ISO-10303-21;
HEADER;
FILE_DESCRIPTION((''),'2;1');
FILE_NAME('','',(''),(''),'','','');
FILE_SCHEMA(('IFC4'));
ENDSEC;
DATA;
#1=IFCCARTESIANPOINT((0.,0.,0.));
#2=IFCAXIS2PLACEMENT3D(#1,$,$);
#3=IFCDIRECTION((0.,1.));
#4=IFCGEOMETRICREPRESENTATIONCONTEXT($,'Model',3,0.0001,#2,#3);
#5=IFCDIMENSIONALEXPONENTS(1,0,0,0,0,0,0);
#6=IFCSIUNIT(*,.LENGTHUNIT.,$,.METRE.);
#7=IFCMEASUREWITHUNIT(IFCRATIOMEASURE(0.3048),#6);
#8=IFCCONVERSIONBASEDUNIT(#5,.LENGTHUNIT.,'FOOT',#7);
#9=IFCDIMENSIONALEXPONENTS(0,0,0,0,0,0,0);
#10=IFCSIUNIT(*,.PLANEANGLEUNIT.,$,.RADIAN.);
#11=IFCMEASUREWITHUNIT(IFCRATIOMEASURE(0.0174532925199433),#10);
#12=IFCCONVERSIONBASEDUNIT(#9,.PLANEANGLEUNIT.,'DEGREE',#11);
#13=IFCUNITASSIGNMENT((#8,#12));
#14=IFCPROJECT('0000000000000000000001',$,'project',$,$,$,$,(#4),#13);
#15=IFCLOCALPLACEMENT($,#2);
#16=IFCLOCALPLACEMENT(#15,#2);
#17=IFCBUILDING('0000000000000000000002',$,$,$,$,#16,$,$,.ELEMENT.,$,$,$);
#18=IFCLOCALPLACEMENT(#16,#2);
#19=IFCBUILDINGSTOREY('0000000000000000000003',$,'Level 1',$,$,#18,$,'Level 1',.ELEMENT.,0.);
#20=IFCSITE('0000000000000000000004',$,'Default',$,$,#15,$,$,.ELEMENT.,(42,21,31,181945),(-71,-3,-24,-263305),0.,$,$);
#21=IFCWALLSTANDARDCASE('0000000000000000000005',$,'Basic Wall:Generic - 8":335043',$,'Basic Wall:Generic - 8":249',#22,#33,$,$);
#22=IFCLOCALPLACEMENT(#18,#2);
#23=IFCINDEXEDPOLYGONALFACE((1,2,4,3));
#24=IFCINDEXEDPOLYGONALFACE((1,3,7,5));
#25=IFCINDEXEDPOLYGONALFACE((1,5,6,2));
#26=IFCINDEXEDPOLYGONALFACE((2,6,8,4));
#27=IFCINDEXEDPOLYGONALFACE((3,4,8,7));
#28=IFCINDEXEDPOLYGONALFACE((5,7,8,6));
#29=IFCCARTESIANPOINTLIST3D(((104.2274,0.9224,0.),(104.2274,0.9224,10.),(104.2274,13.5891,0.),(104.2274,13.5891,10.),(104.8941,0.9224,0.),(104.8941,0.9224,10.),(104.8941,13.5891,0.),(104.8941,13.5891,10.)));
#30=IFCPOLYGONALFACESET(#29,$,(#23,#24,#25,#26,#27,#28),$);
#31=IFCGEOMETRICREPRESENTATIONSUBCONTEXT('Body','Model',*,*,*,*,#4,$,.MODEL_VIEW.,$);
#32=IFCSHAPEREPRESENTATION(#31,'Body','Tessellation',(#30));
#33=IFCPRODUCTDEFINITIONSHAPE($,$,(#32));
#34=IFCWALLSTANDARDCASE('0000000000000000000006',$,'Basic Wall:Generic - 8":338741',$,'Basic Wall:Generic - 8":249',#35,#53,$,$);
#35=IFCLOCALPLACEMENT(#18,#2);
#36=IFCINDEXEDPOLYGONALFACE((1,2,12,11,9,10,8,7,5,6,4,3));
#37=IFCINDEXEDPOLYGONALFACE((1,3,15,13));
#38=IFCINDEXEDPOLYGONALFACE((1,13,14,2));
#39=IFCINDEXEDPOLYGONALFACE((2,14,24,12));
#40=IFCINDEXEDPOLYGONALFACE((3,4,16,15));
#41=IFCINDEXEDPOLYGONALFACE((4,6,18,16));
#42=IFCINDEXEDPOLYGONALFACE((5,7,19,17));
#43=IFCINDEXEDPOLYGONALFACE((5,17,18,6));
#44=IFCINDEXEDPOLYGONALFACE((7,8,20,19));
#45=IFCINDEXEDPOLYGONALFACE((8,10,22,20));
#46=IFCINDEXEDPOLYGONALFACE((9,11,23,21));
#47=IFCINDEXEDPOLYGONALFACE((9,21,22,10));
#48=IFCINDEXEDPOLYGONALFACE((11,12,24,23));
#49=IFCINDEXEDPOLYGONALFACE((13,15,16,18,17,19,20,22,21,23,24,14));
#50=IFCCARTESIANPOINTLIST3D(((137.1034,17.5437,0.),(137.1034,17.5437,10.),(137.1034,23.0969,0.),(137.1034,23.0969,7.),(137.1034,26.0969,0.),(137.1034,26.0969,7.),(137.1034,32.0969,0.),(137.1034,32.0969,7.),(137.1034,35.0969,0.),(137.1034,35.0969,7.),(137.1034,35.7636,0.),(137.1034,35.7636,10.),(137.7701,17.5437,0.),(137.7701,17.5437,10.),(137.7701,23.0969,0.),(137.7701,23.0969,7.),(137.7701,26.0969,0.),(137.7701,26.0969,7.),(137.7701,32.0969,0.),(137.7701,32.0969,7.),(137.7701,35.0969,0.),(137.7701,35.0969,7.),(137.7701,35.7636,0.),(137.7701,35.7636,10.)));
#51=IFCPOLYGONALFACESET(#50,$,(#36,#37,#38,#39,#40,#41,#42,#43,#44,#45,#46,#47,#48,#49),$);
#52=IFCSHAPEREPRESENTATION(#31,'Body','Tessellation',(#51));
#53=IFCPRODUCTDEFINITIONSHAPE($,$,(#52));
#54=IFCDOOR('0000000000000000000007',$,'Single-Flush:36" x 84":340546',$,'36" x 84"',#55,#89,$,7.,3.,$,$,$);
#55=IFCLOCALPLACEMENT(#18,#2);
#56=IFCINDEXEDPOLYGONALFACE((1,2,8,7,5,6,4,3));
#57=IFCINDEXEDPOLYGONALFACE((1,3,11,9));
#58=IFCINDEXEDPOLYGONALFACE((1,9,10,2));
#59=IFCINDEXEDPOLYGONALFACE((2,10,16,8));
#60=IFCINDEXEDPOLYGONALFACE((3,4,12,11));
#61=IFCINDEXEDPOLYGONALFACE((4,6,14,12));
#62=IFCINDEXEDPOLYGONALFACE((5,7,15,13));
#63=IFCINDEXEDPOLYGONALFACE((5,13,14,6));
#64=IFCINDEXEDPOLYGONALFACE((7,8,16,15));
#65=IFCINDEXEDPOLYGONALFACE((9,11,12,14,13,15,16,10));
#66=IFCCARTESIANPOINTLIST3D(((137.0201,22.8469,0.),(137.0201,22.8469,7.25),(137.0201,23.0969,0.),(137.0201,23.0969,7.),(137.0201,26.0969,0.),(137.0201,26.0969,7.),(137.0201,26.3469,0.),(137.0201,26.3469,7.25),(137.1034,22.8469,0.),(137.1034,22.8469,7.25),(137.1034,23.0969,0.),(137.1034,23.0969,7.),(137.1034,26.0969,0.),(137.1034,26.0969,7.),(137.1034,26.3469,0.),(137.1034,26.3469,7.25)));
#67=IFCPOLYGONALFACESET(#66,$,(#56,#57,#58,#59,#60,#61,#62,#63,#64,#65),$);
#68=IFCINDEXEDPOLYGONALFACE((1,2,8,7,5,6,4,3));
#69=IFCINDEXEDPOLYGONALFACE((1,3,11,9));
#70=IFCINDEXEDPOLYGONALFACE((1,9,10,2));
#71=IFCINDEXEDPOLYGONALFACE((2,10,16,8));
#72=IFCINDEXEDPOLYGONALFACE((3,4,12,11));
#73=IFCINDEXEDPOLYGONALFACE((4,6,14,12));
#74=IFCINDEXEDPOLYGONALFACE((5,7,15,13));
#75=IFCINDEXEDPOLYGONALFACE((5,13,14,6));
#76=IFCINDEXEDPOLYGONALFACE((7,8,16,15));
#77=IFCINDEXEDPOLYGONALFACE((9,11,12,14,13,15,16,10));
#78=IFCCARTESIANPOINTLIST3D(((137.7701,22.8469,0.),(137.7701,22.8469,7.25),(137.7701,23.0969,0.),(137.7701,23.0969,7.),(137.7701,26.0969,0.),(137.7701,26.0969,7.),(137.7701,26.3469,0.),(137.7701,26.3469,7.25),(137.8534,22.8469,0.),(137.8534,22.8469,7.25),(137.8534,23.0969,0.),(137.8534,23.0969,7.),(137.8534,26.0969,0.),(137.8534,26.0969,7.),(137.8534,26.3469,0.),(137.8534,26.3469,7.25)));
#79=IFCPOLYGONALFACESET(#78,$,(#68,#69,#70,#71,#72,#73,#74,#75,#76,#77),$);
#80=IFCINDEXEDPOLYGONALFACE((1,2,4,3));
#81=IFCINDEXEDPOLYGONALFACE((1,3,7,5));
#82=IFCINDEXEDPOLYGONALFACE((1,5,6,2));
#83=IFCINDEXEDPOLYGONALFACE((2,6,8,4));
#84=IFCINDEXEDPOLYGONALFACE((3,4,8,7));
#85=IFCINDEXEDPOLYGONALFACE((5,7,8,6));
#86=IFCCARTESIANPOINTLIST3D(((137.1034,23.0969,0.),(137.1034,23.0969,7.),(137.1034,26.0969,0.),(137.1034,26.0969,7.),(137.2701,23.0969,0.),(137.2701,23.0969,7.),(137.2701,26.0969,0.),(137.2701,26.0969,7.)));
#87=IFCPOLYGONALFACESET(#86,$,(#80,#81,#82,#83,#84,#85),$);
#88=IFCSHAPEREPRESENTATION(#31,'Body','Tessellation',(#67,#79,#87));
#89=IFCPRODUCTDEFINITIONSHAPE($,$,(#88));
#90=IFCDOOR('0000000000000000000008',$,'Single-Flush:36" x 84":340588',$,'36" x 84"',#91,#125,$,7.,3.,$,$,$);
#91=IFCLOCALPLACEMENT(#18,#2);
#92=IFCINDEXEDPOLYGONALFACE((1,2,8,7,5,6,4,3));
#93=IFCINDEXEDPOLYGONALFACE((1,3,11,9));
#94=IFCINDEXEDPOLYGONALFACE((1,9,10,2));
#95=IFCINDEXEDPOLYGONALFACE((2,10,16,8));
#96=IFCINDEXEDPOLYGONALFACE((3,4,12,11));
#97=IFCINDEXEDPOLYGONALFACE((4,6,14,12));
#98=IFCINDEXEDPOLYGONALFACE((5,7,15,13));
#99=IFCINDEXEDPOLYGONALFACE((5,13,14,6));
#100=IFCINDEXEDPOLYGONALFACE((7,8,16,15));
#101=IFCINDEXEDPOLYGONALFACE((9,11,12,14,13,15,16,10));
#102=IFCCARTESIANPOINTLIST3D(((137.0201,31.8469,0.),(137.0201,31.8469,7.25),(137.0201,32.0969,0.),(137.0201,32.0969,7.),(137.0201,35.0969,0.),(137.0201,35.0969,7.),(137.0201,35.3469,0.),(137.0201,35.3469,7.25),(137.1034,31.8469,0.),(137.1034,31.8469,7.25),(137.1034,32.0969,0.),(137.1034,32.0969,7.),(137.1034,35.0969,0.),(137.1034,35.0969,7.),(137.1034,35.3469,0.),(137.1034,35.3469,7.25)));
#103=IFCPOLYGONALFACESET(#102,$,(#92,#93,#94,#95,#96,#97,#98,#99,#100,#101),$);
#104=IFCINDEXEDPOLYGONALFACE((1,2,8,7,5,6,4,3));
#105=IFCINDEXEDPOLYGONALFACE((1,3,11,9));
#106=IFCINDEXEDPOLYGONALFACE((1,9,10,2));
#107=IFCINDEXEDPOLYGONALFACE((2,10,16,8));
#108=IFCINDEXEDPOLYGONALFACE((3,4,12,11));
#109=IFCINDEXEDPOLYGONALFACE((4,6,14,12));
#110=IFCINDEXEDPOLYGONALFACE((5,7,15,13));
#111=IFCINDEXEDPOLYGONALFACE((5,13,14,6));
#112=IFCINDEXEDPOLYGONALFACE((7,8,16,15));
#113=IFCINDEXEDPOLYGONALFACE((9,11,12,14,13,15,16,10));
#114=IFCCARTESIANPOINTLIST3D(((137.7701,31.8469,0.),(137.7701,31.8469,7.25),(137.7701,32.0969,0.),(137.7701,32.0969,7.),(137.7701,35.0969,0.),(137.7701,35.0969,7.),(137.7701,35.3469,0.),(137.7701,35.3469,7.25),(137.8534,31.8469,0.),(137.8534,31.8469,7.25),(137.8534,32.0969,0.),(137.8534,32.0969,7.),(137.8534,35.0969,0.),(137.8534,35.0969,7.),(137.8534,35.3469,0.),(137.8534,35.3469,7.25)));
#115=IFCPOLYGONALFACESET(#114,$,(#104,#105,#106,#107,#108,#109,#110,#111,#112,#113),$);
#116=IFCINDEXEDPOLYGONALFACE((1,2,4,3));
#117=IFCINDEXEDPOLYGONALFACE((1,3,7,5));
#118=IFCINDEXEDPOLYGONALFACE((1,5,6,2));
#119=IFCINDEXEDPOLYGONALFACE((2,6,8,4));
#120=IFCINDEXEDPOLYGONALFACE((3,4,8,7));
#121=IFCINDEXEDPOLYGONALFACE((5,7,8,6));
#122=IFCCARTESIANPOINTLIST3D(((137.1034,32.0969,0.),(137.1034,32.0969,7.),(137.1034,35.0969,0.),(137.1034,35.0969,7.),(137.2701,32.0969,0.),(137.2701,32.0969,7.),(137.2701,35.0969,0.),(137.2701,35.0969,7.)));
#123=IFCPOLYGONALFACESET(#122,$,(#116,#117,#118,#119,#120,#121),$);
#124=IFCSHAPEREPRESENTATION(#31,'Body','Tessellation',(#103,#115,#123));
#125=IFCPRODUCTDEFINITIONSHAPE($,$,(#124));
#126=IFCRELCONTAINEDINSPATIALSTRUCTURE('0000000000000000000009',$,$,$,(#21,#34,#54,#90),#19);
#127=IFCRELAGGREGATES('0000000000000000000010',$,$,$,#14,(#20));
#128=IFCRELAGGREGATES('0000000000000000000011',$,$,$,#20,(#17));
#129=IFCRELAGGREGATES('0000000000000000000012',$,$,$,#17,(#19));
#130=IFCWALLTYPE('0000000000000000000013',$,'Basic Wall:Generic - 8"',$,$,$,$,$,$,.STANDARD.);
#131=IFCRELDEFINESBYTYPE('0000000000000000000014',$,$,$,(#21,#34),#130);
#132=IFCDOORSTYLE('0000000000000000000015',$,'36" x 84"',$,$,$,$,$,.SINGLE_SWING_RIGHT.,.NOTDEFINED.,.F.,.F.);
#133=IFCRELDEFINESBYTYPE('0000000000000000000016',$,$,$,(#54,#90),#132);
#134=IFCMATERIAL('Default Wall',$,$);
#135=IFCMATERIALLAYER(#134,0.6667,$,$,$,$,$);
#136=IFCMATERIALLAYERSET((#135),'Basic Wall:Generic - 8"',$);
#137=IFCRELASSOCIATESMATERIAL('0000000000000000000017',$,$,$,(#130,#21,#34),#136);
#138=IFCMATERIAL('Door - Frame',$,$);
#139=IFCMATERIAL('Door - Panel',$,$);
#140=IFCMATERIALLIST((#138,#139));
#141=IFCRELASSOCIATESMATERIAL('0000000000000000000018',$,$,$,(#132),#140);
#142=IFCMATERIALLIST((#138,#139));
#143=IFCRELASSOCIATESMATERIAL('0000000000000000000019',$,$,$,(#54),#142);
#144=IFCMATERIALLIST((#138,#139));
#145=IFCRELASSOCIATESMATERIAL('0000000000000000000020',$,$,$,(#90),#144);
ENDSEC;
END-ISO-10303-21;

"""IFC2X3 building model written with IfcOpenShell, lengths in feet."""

from ifc_helpers import new_model, entity, si_unit, converted_unit, direction, frame, frame_2d, origin, place, context, subcontext, project, spatial, polyline, rectangle, outline, extrude, source, transform, mapped, material, material_list, layer, layer_set, layer_usage, type_object, type_shapes, element, fill, save


model = new_model("IFC2X3")

# Units and contexts
model_context = context("Model", 3, precision=0.0001, world=origin(), true_north=direction((0.0, 1.0)))
body_context = subcontext(model_context, "Body", "Model", "MODEL_VIEW")
ifc_project = project(units=[converted_unit("LENGTHUNIT", "FOOT", entity("IfcRatioMeasure", 0.3048), si_unit("LENGTHUNIT", "METRE"), dimensions=[1, 0, 0, 0, 0, 0, 0]), converted_unit("PLANEANGLEUNIT", "DEGREE", entity("IfcRatioMeasure", 0.0174532925199433), si_unit("PLANEANGLEUNIT", "RADIAN"), dimensions=[0, 0, 0, 0, 0, 0, 0])], contexts=[model_context])

# Site, building, storey
site_placement = place(None, origin())
site = spatial("IfcSite", under=ifc_project, at=site_placement, Name="Default", CompositionType="ELEMENT", RefLatitude=(42, 21, 31, 181945), RefLongitude=(-71, -3, -24, -263305), RefElevation=0.0)
building_placement = place(site_placement, origin())
building = spatial("IfcBuilding", under=site, at=building_placement, CompositionType="ELEMENT")
storey_placement = place(building_placement, origin())
storey = spatial("IfcBuildingStorey", under=building, at=storey_placement, Name="Level 1", LongName="Level 1", CompositionType="ELEMENT", Elevation=0.0)

# Shared definitions
ifc_material_1 = material(Name="Default Wall")
ifc_layer = layer(ifc_material_1, 0.6667)
ifc_layer_set = layer_set([ifc_layer], Name="Basic Wall:Generic - 8\"")
wall_type = type_object("IfcWallType", Name="Basic Wall:Generic - 8\"", PredefinedType="STANDARD", material=ifc_layer_set)

# Shared definitions
ifc_material_2 = material(Name="Door - Frame")
ifc_material_3 = material(Name="Door - Panel")
ifc_material_list_1 = material_list([ifc_material_2, ifc_material_3])
door_style = type_object("IfcDoorStyle", Name="36\" x 84\"", ConstructionType="NOTDEFINED", OperationType="SINGLE_SWING_RIGHT", ParameterTakesPrecedence=False, Sizeable=False, material=ifc_material_list_1)
shared_shape = source(origin(), body_context, "Body", "SweptSolid", [
    extrude(outline(polyline([(-1.75, -3.6875), (1.75, -3.6875), (1.75, 3.5625), (1.5, 3.5625), (1.5, -3.4375), (-1.5, -3.4375), (-1.5, 3.5625), (-1.75, 3.5625), (-1.75, -3.6875)])), frame((1.5, 0.6667, 3.5625), z_axis=(0.0, 1.0, 0.0), x_axis=(1.0, 0.0, 0.0)), (0.0, 0.0, 1.0), 0.0833),
    extrude(outline(polyline([(-3.6875, -1.75), (3.5625, -1.75), (3.5625, -1.5), (-3.4375, -1.5), (-3.4375, 1.5), (3.5625, 1.5), (3.5625, 1.75), (-3.6875, 1.75), (-3.6875, -1.75)])), frame((1.5, -0.0833, 3.5625), z_axis=(0.0, 1.0, 0.0), x_axis=(0.0, 0.0, -1.0)), (0.0, 0.0, 1.0), 0.0833),
    extrude(rectangle(XDim=0.1667, YDim=3.0, at=frame_2d((0.0, 0.0), x_axis=(1.0, 0.0))), frame((1.5, 0.5833, 0.0), z_axis=(0.0, 0.0, 1.0), x_axis=(0.0, 1.0, 0.0)), (0.0, 0.0, 1.0), 7.0),
])
type_shapes(door_style, [shared_shape])

# Wall
ifc_layer_usage_1 = layer_usage(ifc_layer_set, "AXIS2", "NEGATIVE", 0.3333)
wall_1_placement = place(storey_placement, frame((104.5608, 0.9224, 0.0), z_axis=(0.0, 0.0, 1.0), x_axis=(0.0, 1.0, 0.0)))
element("IfcWallStandardCase", 1, at=wall_1_placement, inside=storey, type_object=wall_type, material=ifc_layer_usage_1, Name="Basic Wall:Generic - 8\":335043", ObjectType="Basic Wall:Generic - 8\":249", context=body_context, shape_type="SweptSolid", body=[
    extrude(rectangle(XDim=12.6667, YDim=0.6667, at=frame_2d((6.3333, 0.0), x_axis=(-1.0, 0.0))), origin(), (0.0, 0.0, 1.0), 10.0),
])

# Wall, openings, doors
ifc_layer_usage_2 = layer_usage(ifc_layer_set, "AXIS2", "NEGATIVE", 0.3333)
wall_2_placement = place(storey_placement, frame((137.4368, 35.7636, 0.0), z_axis=(0.0, 0.0, 1.0), x_axis=(0.0, -1.0, 0.0)))
wall_2 = element("IfcWallStandardCase", 2, at=wall_2_placement, inside=storey, type_object=wall_type, material=ifc_layer_usage_2, Name="Basic Wall:Generic - 8\":338741", ObjectType="Basic Wall:Generic - 8\":249", context=body_context, shape_type="SweptSolid", body=[
    extrude(rectangle(XDim=18.2198, YDim=0.6667, at=frame_2d((9.1099, 0.0), x_axis=(-1.0, 0.0))), origin(), (0.0, 0.0, 1.0), 10.0),
])
opening_1_placement = place(wall_2_placement, frame((12.6667, 0.3333, 0.0)))
opening_1 = element("IfcOpeningElement", 3, at=opening_1_placement, cuts=wall_2, ObjectType="Opening", context=body_context, shape_type="SweptSolid", body=[
    extrude(rectangle(XDim=3.0, YDim=7.0, at=frame_2d((3.5, 1.5), x_axis=(0.0, 1.0))), frame((0.0, 0.0, 0.0), z_axis=(0.0, -1.0, 0.0), x_axis=(0.0, 0.0, 1.0)), (0.0, 0.0, 1.0), 0.6667),
])
opening_2_placement = place(wall_2_placement, frame((3.6667, 0.3333, 0.0)))
opening_2 = element("IfcOpeningElement", 4, at=opening_2_placement, cuts=wall_2, ObjectType="Opening", context=body_context, shape_type="SweptSolid", body=[
    extrude(rectangle(XDim=3.0, YDim=7.0, at=frame_2d((3.5, 1.5), x_axis=(0.0, 1.0))), frame((0.0, 0.0, 0.0), z_axis=(0.0, -1.0, 0.0), x_axis=(0.0, 0.0, 1.0)), (0.0, 0.0, 1.0), 0.6667),
])
ifc_material_list_2 = material_list([ifc_material_2, ifc_material_3])
door_1_placement = place(opening_1_placement, frame((0.0, 0.0, 0.0), z_axis=(0.0, 0.0, 1.0), x_axis=(-1.0, 0.0, 0.0)))
door_1 = element("IfcDoor", 5, at=door_1_placement, inside=storey, type_object=door_style, material=ifc_material_list_2, Name="Single-Flush:36\" x 84\":340546", ObjectType="36\" x 84\"", OverallHeight=7.0, OverallWidth=3.0, context=body_context, shape_type="MappedRepresentation", body=[
    mapped(shared_shape, transform((0.0, 0.0, 0.0), scale=1.0)),
])
fill(opening_1, door_1)
ifc_material_list_3 = material_list([ifc_material_2, ifc_material_3])
door_2_placement = place(opening_2_placement, frame((0.0, 0.0, 0.0), z_axis=(0.0, 0.0, 1.0), x_axis=(-1.0, 0.0, 0.0)))
door_2 = element("IfcDoor", 6, at=door_2_placement, inside=storey, type_object=door_style, material=ifc_material_list_3, Name="Single-Flush:36\" x 84\":340588", ObjectType="36\" x 84\"", OverallHeight=7.0, OverallWidth=3.0, context=body_context, shape_type="MappedRepresentation", body=[
    mapped(shared_shape, transform((0.0, 0.0, 0.0), scale=1.0)),
])
fill(opening_2, door_2)

save(model, "model.ifc")
